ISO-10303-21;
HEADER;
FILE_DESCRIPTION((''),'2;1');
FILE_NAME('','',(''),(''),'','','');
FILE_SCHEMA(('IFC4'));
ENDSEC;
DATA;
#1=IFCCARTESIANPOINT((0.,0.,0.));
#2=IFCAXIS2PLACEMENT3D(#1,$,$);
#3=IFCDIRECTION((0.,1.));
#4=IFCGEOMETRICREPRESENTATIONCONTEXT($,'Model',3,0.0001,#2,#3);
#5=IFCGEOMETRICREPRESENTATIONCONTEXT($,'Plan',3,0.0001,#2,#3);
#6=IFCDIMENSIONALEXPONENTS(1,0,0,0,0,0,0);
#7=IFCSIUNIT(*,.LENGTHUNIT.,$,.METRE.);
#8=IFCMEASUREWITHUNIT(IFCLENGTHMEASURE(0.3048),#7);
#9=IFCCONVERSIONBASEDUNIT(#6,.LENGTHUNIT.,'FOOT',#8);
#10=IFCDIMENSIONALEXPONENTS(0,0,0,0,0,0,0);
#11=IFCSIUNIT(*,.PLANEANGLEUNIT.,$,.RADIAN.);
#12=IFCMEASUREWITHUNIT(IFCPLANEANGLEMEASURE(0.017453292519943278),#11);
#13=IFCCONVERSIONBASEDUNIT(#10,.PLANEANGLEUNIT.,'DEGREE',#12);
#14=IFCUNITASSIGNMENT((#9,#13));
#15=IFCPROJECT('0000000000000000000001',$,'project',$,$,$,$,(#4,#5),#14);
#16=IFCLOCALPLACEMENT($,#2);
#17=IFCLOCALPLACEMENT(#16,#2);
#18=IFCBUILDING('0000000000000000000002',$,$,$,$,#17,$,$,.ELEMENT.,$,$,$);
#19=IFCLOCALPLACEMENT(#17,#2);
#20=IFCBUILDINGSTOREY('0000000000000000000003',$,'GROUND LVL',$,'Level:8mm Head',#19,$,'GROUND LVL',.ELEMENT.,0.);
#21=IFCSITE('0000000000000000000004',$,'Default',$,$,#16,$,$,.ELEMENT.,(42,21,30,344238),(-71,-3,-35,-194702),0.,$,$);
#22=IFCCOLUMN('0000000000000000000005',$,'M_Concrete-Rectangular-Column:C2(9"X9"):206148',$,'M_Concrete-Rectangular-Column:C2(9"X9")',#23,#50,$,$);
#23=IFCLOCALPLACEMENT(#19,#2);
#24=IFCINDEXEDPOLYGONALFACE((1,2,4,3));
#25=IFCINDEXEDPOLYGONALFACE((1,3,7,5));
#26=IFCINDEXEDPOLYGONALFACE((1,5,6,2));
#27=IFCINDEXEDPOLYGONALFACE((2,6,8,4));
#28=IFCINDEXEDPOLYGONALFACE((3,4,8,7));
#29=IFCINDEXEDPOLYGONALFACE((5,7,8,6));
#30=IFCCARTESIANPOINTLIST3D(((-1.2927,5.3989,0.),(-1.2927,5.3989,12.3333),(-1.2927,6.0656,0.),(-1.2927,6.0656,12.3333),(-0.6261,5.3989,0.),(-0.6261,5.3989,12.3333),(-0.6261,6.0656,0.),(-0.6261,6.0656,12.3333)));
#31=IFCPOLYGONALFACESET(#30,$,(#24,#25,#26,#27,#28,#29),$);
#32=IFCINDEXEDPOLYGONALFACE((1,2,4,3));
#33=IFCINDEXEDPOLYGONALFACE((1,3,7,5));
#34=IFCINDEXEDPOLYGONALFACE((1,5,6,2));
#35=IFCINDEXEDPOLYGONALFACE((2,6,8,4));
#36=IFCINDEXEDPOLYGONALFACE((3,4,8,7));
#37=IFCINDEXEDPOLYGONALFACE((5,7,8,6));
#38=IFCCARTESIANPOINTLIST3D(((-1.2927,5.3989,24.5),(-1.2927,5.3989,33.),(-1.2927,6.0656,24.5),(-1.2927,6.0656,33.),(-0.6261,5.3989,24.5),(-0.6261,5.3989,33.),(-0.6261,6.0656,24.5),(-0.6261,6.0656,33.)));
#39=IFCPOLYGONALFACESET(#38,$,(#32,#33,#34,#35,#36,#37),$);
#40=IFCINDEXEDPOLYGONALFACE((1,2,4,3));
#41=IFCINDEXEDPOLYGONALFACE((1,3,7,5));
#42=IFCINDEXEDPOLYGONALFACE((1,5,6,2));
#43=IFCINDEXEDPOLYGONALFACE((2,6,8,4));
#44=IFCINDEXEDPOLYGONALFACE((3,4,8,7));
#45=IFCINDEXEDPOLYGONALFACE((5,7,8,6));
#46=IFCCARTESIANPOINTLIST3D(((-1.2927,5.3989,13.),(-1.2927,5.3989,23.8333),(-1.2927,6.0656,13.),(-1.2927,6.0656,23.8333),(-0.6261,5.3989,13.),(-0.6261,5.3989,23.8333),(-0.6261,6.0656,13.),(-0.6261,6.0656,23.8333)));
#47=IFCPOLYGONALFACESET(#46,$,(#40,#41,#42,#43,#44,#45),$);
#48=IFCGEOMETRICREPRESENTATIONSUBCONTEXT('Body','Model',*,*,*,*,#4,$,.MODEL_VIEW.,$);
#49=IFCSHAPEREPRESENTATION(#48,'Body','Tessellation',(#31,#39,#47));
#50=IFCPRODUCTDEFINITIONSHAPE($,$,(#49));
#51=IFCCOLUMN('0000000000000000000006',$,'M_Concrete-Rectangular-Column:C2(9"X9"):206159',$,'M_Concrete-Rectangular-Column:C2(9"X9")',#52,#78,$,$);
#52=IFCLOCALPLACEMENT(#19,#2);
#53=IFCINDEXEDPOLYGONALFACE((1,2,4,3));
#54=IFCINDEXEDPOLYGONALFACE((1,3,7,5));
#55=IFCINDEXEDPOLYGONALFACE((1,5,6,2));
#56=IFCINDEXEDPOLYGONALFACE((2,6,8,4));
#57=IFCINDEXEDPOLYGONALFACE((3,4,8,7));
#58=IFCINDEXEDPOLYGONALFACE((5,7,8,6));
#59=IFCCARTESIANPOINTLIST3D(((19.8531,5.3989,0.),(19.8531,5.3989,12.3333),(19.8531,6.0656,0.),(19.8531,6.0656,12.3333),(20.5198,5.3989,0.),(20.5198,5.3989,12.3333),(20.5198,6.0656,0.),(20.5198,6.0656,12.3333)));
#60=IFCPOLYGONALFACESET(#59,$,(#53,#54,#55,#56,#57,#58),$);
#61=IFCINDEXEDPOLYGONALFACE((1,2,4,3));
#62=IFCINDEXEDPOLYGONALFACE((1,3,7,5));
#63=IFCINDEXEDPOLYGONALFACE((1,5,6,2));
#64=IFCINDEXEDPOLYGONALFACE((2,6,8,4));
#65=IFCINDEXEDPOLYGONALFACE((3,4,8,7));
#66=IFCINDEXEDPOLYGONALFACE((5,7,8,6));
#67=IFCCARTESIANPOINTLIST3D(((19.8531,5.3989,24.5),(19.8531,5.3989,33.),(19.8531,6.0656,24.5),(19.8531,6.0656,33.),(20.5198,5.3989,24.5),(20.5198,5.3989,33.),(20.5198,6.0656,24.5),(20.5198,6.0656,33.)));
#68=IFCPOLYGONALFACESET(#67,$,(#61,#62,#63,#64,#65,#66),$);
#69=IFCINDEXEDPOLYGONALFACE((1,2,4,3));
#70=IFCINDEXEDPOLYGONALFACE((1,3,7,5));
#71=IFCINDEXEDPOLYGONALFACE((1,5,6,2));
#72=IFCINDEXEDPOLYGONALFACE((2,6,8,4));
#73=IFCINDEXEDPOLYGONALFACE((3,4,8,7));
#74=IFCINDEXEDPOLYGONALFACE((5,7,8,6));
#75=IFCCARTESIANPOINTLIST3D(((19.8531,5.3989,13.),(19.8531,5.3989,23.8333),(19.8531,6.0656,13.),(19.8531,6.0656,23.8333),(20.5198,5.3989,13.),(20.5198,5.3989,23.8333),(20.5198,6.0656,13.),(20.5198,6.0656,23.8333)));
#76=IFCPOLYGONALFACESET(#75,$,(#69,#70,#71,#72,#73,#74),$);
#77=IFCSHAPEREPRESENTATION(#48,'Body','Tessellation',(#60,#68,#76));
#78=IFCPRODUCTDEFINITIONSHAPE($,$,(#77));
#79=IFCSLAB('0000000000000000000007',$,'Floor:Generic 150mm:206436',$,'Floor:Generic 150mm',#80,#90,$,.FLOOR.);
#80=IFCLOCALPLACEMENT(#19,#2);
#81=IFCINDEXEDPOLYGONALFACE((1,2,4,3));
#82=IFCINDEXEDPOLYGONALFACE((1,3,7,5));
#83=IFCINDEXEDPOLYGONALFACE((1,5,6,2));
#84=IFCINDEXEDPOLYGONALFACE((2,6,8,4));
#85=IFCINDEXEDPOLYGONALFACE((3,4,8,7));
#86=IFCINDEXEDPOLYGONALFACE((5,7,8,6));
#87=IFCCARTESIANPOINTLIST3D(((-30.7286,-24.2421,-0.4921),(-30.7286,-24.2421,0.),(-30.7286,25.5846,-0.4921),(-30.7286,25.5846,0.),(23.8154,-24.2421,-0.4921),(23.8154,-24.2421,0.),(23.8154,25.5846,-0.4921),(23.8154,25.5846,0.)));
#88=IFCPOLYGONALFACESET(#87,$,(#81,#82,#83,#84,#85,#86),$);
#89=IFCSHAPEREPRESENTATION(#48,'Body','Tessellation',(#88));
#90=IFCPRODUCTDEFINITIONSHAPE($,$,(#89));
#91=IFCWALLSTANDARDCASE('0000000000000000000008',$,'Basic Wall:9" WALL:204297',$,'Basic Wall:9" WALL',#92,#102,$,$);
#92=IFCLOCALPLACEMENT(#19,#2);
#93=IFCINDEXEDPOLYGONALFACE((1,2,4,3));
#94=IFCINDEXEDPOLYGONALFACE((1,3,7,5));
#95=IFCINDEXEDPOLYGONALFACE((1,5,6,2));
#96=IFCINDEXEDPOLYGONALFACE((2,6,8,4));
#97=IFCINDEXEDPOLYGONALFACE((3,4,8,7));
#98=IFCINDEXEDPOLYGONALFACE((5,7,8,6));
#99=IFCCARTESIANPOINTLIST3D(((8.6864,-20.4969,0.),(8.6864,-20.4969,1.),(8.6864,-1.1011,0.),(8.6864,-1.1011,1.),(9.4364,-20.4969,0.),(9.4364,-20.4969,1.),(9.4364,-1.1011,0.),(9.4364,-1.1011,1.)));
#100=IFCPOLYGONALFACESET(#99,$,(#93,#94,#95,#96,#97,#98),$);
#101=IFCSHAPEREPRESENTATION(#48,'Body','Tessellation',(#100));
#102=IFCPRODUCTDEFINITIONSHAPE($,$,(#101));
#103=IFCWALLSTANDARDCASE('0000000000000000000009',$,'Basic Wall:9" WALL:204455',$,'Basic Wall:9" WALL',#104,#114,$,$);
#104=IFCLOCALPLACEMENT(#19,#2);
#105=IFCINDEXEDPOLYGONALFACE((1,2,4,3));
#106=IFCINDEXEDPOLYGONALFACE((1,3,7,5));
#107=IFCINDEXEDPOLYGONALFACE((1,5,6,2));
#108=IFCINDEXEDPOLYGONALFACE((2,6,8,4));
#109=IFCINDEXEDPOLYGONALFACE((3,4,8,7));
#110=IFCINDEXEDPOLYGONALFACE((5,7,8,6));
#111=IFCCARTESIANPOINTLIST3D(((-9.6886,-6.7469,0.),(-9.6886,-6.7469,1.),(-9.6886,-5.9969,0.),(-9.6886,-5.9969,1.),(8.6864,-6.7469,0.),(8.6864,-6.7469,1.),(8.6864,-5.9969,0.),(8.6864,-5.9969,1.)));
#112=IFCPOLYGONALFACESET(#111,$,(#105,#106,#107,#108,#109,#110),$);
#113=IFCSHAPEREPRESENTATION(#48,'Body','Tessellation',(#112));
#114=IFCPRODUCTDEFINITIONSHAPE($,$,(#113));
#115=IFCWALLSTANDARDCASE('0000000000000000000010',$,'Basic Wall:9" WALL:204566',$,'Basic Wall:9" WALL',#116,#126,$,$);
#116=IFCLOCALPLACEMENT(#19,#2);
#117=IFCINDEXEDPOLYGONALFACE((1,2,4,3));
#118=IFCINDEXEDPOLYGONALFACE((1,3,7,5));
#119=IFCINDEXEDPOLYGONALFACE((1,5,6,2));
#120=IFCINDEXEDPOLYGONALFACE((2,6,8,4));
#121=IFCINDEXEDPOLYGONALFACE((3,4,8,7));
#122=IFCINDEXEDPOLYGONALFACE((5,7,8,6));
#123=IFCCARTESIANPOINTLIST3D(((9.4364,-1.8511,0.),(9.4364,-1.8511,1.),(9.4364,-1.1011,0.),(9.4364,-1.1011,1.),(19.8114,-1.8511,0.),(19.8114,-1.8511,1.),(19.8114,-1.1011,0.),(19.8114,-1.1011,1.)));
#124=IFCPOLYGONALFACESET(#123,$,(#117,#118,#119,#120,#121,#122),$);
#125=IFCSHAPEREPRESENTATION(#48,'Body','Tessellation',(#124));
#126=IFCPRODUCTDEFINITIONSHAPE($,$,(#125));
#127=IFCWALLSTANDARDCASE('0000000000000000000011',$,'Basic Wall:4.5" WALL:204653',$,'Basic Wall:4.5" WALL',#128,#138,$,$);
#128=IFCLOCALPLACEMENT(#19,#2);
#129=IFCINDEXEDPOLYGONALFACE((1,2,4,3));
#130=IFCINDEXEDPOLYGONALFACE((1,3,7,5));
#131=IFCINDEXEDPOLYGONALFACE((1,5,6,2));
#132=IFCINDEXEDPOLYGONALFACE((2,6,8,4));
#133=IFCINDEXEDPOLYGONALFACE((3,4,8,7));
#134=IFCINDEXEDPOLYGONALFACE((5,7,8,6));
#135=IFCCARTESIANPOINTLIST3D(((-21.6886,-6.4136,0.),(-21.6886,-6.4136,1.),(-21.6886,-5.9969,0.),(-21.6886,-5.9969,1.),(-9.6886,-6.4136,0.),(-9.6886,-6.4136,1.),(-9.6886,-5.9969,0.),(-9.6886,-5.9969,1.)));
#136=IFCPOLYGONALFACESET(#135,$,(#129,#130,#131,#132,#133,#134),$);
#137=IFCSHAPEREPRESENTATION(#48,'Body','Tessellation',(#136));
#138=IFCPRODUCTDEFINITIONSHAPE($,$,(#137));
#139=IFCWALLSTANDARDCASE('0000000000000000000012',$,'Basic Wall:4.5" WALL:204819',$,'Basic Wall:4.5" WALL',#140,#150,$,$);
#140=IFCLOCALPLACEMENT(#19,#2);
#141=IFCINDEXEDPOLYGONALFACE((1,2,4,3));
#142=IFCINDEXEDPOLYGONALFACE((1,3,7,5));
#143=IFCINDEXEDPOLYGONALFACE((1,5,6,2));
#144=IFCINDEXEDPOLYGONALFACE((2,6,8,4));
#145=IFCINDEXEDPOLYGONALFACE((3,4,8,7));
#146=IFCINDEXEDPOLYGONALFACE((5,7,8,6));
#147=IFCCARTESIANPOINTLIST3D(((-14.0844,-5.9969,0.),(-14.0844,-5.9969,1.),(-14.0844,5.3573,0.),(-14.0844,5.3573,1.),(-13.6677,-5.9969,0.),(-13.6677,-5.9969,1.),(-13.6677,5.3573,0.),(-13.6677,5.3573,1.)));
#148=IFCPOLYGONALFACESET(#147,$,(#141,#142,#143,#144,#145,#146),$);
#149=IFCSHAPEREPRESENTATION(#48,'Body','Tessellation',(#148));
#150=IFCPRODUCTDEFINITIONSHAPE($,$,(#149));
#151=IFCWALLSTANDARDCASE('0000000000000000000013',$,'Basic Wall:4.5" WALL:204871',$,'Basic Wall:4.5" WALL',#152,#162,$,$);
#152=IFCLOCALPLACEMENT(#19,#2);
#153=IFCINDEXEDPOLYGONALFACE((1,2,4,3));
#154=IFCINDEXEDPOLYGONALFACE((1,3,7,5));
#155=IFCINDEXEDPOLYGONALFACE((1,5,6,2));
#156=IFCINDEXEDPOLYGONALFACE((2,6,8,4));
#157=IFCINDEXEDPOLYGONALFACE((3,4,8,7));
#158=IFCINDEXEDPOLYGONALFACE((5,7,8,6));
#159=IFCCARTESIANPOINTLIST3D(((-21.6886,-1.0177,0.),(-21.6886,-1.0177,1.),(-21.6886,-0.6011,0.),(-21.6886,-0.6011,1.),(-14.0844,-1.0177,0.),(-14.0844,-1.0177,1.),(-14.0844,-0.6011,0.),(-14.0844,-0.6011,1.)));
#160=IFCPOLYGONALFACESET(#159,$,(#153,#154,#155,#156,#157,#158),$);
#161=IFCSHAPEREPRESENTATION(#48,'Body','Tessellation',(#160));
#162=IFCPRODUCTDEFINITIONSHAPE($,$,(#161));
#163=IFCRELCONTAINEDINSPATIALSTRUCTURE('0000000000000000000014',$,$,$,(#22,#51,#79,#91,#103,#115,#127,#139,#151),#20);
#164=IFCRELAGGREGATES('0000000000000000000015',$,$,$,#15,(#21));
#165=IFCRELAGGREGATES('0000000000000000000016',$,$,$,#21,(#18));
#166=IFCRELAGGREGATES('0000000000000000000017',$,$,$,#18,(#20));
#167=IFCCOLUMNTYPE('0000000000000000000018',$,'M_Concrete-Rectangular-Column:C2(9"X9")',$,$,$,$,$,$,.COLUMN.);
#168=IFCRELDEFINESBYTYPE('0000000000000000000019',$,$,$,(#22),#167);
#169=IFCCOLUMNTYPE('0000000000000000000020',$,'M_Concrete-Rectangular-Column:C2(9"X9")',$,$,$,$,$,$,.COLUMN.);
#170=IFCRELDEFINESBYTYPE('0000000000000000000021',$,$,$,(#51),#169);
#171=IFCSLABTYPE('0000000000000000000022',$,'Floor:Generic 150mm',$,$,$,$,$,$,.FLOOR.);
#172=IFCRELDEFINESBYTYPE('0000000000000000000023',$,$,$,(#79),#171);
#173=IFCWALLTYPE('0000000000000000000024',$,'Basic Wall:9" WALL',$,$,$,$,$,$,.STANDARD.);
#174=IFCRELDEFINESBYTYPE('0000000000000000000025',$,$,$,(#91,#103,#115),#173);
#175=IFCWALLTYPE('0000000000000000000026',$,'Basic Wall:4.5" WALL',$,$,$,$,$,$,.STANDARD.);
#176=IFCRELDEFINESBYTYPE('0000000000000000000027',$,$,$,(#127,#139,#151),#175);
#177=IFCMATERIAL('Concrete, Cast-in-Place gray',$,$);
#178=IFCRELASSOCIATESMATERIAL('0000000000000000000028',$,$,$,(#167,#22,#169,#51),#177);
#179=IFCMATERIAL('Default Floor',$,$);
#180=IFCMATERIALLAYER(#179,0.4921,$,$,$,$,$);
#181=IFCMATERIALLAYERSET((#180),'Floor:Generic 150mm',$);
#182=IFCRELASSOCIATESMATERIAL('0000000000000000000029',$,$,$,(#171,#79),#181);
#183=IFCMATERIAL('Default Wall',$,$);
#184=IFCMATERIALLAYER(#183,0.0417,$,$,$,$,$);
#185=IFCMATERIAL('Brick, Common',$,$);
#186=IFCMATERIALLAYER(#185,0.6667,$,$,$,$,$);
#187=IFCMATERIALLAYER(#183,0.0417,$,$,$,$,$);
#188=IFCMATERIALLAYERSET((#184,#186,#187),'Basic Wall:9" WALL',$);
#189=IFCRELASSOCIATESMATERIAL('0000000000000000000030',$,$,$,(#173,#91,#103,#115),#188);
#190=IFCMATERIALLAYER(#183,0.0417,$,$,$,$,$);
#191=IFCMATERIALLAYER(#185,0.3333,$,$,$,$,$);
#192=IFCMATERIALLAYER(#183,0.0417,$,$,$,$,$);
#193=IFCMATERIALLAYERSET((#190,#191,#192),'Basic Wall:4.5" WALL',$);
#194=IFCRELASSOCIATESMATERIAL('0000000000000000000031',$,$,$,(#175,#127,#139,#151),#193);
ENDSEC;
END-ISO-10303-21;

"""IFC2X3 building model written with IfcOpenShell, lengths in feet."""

from ifc_helpers import new_model, entity, si_unit, converted_unit, direction, frame, frame_2d, origin, origin_2d_with_axis, place, context, subcontext, project, spatial, polyline, rectangle, extrude, clip, bounded_halfspace, source, transform, mapped, material, layer, layer_set, layer_usage, type_object, type_shapes, element, save


model = new_model("IFC2X3")

# Units and contexts
model_context = context("Model", 3, precision=0.0001, world=origin(), true_north=direction((0.0, 1.0)))
plan_context = context("Plan", 3, precision=0.0001, world=origin(), true_north=direction((0.0, 1.0)))
body_context = subcontext(model_context, "Body", "Model", "MODEL_VIEW")
ifc_project = project(units=[converted_unit("LENGTHUNIT", "FOOT", entity("IfcLengthMeasure", 0.3048), si_unit("LENGTHUNIT", "METRE"), dimensions=[1, 0, 0, 0, 0, 0, 0]), converted_unit("PLANEANGLEUNIT", "DEGREE", entity("IfcPlaneAngleMeasure", 0.017453292519943278), si_unit("PLANEANGLEUNIT", "RADIAN"), dimensions=[0, 0, 0, 0, 0, 0, 0])], contexts=[model_context, plan_context])

# Site, building, storey
site_placement = place(None, origin())
site = spatial("IfcSite", under=ifc_project, at=site_placement, Name="Default", CompositionType="ELEMENT", RefLatitude=(42, 21, 30, 344238), RefLongitude=(-71, -3, -35, -194702), RefElevation=0.0)
building_placement = place(site_placement, origin())
building = spatial("IfcBuilding", under=site, at=building_placement, CompositionType="ELEMENT")
storey_placement = place(building_placement, origin())
storey = spatial("IfcBuildingStorey", under=building, at=storey_placement, Name="GROUND LVL", ObjectType="Level:8mm Head", LongName="GROUND LVL", CompositionType="ELEMENT", Elevation=0.0)

# Columns
ifc_material_1 = material(Name="Concrete, Cast-in-Place gray")
column_type_1 = type_object("IfcColumnType", Name="M_Concrete-Rectangular-Column:C2(9\"X9\")", PredefinedType="COLUMN", material=ifc_material_1)
shared_shape_1 = source(origin(), body_context, "Body", "SweptSolid", [
    extrude(rectangle(XDim=0.6667, YDim=0.6667, at=frame_2d((0.0, 0.0), x_axis=(1.0, 0.0))), frame((-0.9594, 5.7323, 0.0)), (0.0, 0.0, 1.0), 12.3333),
    extrude(rectangle(XDim=0.6667, YDim=0.6667, at=frame_2d((0.0, 0.0), x_axis=(1.0, 0.0))), frame((-0.9594, 5.7323, 24.5)), (0.0, 0.0, 1.0), 8.5),
    extrude(rectangle(XDim=0.6667, YDim=0.6667, at=frame_2d((0.0, 0.0), x_axis=(1.0, 0.0))), frame((-0.9594, 5.7323, 13.0)), (0.0, 0.0, 1.0), 10.8333),
])
type_shapes(column_type_1, [shared_shape_1])
column_1_placement = place(storey_placement, origin())
element("IfcColumn", 1, at=column_1_placement, inside=storey, type_object=column_type_1, material=ifc_material_1, Name="M_Concrete-Rectangular-Column:C2(9\"X9\"):206148", ObjectType="M_Concrete-Rectangular-Column:C2(9\"X9\")", context=body_context, shape_type="MappedRepresentation", body=[
    mapped(shared_shape_1, transform((0.0, 0.0, 0.0), scale=1.0)),
])
column_type_2 = type_object("IfcColumnType", Name="M_Concrete-Rectangular-Column:C2(9\"X9\")", PredefinedType="COLUMN", material=ifc_material_1)
shared_shape_2 = source(origin(), body_context, "Body", "SweptSolid", [
    extrude(rectangle(XDim=0.6667, YDim=0.6667, at=frame_2d((0.0, 0.0), x_axis=(1.0, 0.0))), frame((20.1864, 5.7323, 0.0)), (0.0, 0.0, 1.0), 12.3333),
    extrude(rectangle(XDim=0.6667, YDim=0.6667, at=origin_2d_with_axis()), frame((20.1864, 5.7323, 24.5)), (0.0, 0.0, 1.0), 8.5),
    extrude(rectangle(XDim=0.6667, YDim=0.6667, at=origin_2d_with_axis()), frame((20.1864, 5.7323, 13.0)), (0.0, 0.0, 1.0), 10.8333),
])
type_shapes(column_type_2, [shared_shape_2])
column_2_placement = place(storey_placement, origin())
element("IfcColumn", 2, at=column_2_placement, inside=storey, type_object=column_type_2, material=ifc_material_1, Name="M_Concrete-Rectangular-Column:C2(9\"X9\"):206159", ObjectType="M_Concrete-Rectangular-Column:C2(9\"X9\")", context=body_context, shape_type="MappedRepresentation", body=[
    mapped(shared_shape_2, transform((0.0, 0.0, 0.0), scale=1.0)),
])

# Slab
ifc_material_2 = material(Name="Default Floor")
ifc_layer_1 = layer(ifc_material_2, 0.4921)
ifc_layer_set_1 = layer_set([ifc_layer_1], Name="Floor:Generic 150mm")
ifc_layer_usage_1 = layer_usage(ifc_layer_set_1, "AXIS3", "POSITIVE", 0.0)
slab_type = type_object("IfcSlabType", Name="Floor:Generic 150mm", PredefinedType="FLOOR", material=ifc_layer_set_1)
slab_placement = place(storey_placement, origin())
element("IfcSlab", 3, at=slab_placement, inside=storey, type_object=slab_type, material=ifc_layer_usage_1, Name="Floor:Generic 150mm:206436", ObjectType="Floor:Generic 150mm", PredefinedType="FLOOR", context=body_context, shape_type="SweptSolid", body=[
    extrude(rectangle(XDim=49.8268, YDim=54.544, at=origin_2d_with_axis()), frame((-3.4566, 0.6713, 0.0), z_axis=(0.0, 0.0, -1.0), x_axis=(0.0, 1.0, 0.0)), (0.0, 0.0, 1.0), 0.4921),
])

# Walls
ifc_material_3 = material(Name="Default Wall")
ifc_layer_2 = layer(ifc_material_3, 0.0417)
ifc_material_4 = material(Name="Brick, Common")
ifc_layer_3 = layer(ifc_material_4, 0.6667)
ifc_layer_4 = layer(ifc_material_3, 0.0417)
ifc_layer_set_2 = layer_set([ifc_layer_2, ifc_layer_3, ifc_layer_4], Name="Basic Wall:9\" WALL")
wall_type_1 = type_object("IfcWallType", Name="Basic Wall:9\" WALL", PredefinedType="STANDARD", material=ifc_layer_set_2)
ifc_layer_usage_2 = layer_usage(ifc_layer_set_2, "AXIS2", "NEGATIVE", 0.375)
wall_1_placement = place(storey_placement, frame((9.0614, -20.4969, 0.0), z_axis=(0.0, 0.0, 1.0), x_axis=(0.0, 1.0, 0.0)))
element("IfcWallStandardCase", 4, at=wall_1_placement, inside=storey, type_object=wall_type_1, material=ifc_layer_usage_2, Name="Basic Wall:9\" WALL:204297", ObjectType="Basic Wall:9\" WALL", context=body_context, shape_type="Clipping", body=[
    clip(extrude(rectangle(XDim=19.3958, YDim=0.75, at=frame_2d((9.6979, 0.0), x_axis=(-1.0, 0.0))), origin(), (0.0, 0.0, 1.0), 1.0), bounded_halfspace(frame((0.0, -0.375, 1.0), z_axis=(0.0, 0.0, -1.0), x_axis=(-1.0, 0.0, 0.0)), True, frame((0.0, -0.375, 1.0)), polyline([(0.0, 0.0), (18.6458, 0.0), (19.3958, 0.0), (19.3958, 0.75), (14.5, 0.75), (13.75, 0.75), (0.0, 0.75), (0.0, 0.0)]))),
])
ifc_layer_usage_3 = layer_usage(ifc_layer_set_2, "AXIS2", "NEGATIVE", 0.375)
wall_2_placement = place(storey_placement, frame((8.6864, -6.3719, 0.0), z_axis=(0.0, 0.0, 1.0), x_axis=(-1.0, 0.0, 0.0)))
element("IfcWallStandardCase", 5, at=wall_2_placement, inside=storey, type_object=wall_type_1, material=ifc_layer_usage_3, Name="Basic Wall:9\" WALL:204455", ObjectType="Basic Wall:9\" WALL", context=body_context, shape_type="Clipping", body=[
    clip(extrude(rectangle(XDim=18.375, YDim=0.75, at=frame_2d((9.1875, 0.0), x_axis=(-1.0, 0.0))), origin(), (0.0, 0.0, 1.0), 1.0), bounded_halfspace(frame((0.0, -0.375, 1.0), z_axis=(0.0, 0.0, -1.0), x_axis=(0.0, 1.0, 0.0)), True, frame((0.0, -0.375, 1.0)), polyline([(0.0, 0.0), (18.375, 0.0), (18.375, 0.4167), (18.375, 0.75), (0.0, 0.75), (0.0, 0.0)]))),
])
ifc_layer_usage_4 = layer_usage(ifc_layer_set_2, "AXIS2", "NEGATIVE", 0.375)
wall_3_placement = place(storey_placement, frame((19.8114, -1.4761, 0.0), z_axis=(0.0, 0.0, 1.0), x_axis=(-1.0, 0.0, 0.0)))
element("IfcWallStandardCase", 6, at=wall_3_placement, inside=storey, type_object=wall_type_1, material=ifc_layer_usage_4, Name="Basic Wall:9\" WALL:204566", ObjectType="Basic Wall:9\" WALL", context=body_context, shape_type="Clipping", body=[
    clip(extrude(rectangle(XDim=10.375, YDim=0.75, at=frame_2d((5.1875, 0.0), x_axis=(-1.0, 0.0))), origin(), (0.0, 0.0, 1.0), 1.0), bounded_halfspace(frame((0.0, -0.375, 1.0), z_axis=(0.0, 0.0, -1.0), x_axis=(0.0, 1.0, 0.0)), True, frame((0.0, -0.375, 1.0)), polyline([(0.0, 0.0), (6.9832, 0.0), (7.3998, 0.0), (10.375, 0.0), (10.375, 0.75), (0.0, 0.75), (0.0, 0.0)]))),
])
ifc_layer_5 = layer(ifc_material_3, 0.0417)
ifc_layer_6 = layer(ifc_material_4, 0.3333)
ifc_layer_7 = layer(ifc_material_3, 0.0417)
ifc_layer_set_3 = layer_set([ifc_layer_5, ifc_layer_6, ifc_layer_7], Name="Basic Wall:4.5\" WALL")
ifc_layer_usage_5 = layer_usage(ifc_layer_set_3, "AXIS2", "NEGATIVE", 0.2083)
wall_type_2 = type_object("IfcWallType", Name="Basic Wall:4.5\" WALL", PredefinedType="STANDARD", material=ifc_layer_set_3)
wall_4_placement = place(storey_placement, frame((-9.6886, -6.2052, 0.0), z_axis=(0.0, 0.0, 1.0), x_axis=(-1.0, 0.0, 0.0)))
element("IfcWallStandardCase", 7, at=wall_4_placement, inside=storey, type_object=wall_type_2, material=ifc_layer_usage_5, Name="Basic Wall:4.5\" WALL:204653", ObjectType="Basic Wall:4.5\" WALL", context=body_context, shape_type="Clipping", body=[
    clip(extrude(rectangle(XDim=12.0, YDim=0.4167, at=frame_2d((6.0, 0.0), x_axis=(-1.0, 0.0))), origin(), (0.0, 0.0, 1.0), 1.0), bounded_halfspace(frame((0.0, -0.2083, 1.0), z_axis=(0.0, 0.0, -1.0), x_axis=(0.0, 1.0, 0.0)), True, frame((0.0, -0.2083, 1.0)), polyline([(0.0, 0.0), (3.9792, 0.0), (4.3958, 0.0), (12.0, 0.0), (12.0, 0.4167), (0.0, 0.4167), (0.0, 0.0)]))),
])
ifc_layer_usage_6 = layer_usage(ifc_layer_set_3, "AXIS2", "NEGATIVE", 0.2083)
wall_5_placement = place(storey_placement, frame((-13.8761, 5.3573, 0.0), z_axis=(0.0, 0.0, 1.0), x_axis=(0.0, -1.0, 0.0)))
element("IfcWallStandardCase", 8, at=wall_5_placement, inside=storey, type_object=wall_type_2, material=ifc_layer_usage_6, Name="Basic Wall:4.5\" WALL:204819", ObjectType="Basic Wall:4.5\" WALL", context=body_context, shape_type="Clipping", body=[
    clip(extrude(rectangle(XDim=11.3542, YDim=0.4167, at=frame_2d((5.6771, 0.0), x_axis=(-1.0, 0.0))), origin(), (0.0, 0.0, 1.0), 1.0), bounded_halfspace(frame((0.0, -0.2083, 1.0), z_axis=(0.0, 0.0, -1.0), x_axis=(1.0, 0.0, 0.0)), True, frame((0.0, -0.2083, 1.0)), polyline([(0.0, 0.0), (5.9583, 0.0), (6.375, 0.0), (11.3542, 0.0), (11.3542, 0.4167), (0.0, 0.4167), (0.0, 0.0)]))),
])
ifc_layer_usage_7 = layer_usage(ifc_layer_set_3, "AXIS2", "NEGATIVE", 0.2083)
wall_6_placement = place(storey_placement, frame((-14.0844, -0.8094, 0.0), z_axis=(0.0, 0.0, 1.0), x_axis=(-1.0, 0.0, 0.0)))
element("IfcWallStandardCase", 9, at=wall_6_placement, inside=storey, type_object=wall_type_2, material=ifc_layer_usage_7, Name="Basic Wall:4.5\" WALL:204871", ObjectType="Basic Wall:4.5\" WALL", context=body_context, shape_type="Clipping", body=[
    clip(extrude(rectangle(XDim=7.6042, YDim=0.4167, at=frame_2d((3.8021, 0.0), x_axis=(-1.0, 0.0))), origin(), (0.0, 0.0, 1.0), 1.0), bounded_halfspace(frame((0.0, -0.2083, 1.0), z_axis=(0.0, 0.0, -1.0), x_axis=(0.0, 1.0, 0.0)), True, frame((0.0, -0.2083, 1.0)), polyline([(0.0, 0.0), (7.6042, 0.0), (7.6042, 0.4167), (0.0, 0.4167), (0.0, 0.0)]))),
])

save(model, "model.ifc")
